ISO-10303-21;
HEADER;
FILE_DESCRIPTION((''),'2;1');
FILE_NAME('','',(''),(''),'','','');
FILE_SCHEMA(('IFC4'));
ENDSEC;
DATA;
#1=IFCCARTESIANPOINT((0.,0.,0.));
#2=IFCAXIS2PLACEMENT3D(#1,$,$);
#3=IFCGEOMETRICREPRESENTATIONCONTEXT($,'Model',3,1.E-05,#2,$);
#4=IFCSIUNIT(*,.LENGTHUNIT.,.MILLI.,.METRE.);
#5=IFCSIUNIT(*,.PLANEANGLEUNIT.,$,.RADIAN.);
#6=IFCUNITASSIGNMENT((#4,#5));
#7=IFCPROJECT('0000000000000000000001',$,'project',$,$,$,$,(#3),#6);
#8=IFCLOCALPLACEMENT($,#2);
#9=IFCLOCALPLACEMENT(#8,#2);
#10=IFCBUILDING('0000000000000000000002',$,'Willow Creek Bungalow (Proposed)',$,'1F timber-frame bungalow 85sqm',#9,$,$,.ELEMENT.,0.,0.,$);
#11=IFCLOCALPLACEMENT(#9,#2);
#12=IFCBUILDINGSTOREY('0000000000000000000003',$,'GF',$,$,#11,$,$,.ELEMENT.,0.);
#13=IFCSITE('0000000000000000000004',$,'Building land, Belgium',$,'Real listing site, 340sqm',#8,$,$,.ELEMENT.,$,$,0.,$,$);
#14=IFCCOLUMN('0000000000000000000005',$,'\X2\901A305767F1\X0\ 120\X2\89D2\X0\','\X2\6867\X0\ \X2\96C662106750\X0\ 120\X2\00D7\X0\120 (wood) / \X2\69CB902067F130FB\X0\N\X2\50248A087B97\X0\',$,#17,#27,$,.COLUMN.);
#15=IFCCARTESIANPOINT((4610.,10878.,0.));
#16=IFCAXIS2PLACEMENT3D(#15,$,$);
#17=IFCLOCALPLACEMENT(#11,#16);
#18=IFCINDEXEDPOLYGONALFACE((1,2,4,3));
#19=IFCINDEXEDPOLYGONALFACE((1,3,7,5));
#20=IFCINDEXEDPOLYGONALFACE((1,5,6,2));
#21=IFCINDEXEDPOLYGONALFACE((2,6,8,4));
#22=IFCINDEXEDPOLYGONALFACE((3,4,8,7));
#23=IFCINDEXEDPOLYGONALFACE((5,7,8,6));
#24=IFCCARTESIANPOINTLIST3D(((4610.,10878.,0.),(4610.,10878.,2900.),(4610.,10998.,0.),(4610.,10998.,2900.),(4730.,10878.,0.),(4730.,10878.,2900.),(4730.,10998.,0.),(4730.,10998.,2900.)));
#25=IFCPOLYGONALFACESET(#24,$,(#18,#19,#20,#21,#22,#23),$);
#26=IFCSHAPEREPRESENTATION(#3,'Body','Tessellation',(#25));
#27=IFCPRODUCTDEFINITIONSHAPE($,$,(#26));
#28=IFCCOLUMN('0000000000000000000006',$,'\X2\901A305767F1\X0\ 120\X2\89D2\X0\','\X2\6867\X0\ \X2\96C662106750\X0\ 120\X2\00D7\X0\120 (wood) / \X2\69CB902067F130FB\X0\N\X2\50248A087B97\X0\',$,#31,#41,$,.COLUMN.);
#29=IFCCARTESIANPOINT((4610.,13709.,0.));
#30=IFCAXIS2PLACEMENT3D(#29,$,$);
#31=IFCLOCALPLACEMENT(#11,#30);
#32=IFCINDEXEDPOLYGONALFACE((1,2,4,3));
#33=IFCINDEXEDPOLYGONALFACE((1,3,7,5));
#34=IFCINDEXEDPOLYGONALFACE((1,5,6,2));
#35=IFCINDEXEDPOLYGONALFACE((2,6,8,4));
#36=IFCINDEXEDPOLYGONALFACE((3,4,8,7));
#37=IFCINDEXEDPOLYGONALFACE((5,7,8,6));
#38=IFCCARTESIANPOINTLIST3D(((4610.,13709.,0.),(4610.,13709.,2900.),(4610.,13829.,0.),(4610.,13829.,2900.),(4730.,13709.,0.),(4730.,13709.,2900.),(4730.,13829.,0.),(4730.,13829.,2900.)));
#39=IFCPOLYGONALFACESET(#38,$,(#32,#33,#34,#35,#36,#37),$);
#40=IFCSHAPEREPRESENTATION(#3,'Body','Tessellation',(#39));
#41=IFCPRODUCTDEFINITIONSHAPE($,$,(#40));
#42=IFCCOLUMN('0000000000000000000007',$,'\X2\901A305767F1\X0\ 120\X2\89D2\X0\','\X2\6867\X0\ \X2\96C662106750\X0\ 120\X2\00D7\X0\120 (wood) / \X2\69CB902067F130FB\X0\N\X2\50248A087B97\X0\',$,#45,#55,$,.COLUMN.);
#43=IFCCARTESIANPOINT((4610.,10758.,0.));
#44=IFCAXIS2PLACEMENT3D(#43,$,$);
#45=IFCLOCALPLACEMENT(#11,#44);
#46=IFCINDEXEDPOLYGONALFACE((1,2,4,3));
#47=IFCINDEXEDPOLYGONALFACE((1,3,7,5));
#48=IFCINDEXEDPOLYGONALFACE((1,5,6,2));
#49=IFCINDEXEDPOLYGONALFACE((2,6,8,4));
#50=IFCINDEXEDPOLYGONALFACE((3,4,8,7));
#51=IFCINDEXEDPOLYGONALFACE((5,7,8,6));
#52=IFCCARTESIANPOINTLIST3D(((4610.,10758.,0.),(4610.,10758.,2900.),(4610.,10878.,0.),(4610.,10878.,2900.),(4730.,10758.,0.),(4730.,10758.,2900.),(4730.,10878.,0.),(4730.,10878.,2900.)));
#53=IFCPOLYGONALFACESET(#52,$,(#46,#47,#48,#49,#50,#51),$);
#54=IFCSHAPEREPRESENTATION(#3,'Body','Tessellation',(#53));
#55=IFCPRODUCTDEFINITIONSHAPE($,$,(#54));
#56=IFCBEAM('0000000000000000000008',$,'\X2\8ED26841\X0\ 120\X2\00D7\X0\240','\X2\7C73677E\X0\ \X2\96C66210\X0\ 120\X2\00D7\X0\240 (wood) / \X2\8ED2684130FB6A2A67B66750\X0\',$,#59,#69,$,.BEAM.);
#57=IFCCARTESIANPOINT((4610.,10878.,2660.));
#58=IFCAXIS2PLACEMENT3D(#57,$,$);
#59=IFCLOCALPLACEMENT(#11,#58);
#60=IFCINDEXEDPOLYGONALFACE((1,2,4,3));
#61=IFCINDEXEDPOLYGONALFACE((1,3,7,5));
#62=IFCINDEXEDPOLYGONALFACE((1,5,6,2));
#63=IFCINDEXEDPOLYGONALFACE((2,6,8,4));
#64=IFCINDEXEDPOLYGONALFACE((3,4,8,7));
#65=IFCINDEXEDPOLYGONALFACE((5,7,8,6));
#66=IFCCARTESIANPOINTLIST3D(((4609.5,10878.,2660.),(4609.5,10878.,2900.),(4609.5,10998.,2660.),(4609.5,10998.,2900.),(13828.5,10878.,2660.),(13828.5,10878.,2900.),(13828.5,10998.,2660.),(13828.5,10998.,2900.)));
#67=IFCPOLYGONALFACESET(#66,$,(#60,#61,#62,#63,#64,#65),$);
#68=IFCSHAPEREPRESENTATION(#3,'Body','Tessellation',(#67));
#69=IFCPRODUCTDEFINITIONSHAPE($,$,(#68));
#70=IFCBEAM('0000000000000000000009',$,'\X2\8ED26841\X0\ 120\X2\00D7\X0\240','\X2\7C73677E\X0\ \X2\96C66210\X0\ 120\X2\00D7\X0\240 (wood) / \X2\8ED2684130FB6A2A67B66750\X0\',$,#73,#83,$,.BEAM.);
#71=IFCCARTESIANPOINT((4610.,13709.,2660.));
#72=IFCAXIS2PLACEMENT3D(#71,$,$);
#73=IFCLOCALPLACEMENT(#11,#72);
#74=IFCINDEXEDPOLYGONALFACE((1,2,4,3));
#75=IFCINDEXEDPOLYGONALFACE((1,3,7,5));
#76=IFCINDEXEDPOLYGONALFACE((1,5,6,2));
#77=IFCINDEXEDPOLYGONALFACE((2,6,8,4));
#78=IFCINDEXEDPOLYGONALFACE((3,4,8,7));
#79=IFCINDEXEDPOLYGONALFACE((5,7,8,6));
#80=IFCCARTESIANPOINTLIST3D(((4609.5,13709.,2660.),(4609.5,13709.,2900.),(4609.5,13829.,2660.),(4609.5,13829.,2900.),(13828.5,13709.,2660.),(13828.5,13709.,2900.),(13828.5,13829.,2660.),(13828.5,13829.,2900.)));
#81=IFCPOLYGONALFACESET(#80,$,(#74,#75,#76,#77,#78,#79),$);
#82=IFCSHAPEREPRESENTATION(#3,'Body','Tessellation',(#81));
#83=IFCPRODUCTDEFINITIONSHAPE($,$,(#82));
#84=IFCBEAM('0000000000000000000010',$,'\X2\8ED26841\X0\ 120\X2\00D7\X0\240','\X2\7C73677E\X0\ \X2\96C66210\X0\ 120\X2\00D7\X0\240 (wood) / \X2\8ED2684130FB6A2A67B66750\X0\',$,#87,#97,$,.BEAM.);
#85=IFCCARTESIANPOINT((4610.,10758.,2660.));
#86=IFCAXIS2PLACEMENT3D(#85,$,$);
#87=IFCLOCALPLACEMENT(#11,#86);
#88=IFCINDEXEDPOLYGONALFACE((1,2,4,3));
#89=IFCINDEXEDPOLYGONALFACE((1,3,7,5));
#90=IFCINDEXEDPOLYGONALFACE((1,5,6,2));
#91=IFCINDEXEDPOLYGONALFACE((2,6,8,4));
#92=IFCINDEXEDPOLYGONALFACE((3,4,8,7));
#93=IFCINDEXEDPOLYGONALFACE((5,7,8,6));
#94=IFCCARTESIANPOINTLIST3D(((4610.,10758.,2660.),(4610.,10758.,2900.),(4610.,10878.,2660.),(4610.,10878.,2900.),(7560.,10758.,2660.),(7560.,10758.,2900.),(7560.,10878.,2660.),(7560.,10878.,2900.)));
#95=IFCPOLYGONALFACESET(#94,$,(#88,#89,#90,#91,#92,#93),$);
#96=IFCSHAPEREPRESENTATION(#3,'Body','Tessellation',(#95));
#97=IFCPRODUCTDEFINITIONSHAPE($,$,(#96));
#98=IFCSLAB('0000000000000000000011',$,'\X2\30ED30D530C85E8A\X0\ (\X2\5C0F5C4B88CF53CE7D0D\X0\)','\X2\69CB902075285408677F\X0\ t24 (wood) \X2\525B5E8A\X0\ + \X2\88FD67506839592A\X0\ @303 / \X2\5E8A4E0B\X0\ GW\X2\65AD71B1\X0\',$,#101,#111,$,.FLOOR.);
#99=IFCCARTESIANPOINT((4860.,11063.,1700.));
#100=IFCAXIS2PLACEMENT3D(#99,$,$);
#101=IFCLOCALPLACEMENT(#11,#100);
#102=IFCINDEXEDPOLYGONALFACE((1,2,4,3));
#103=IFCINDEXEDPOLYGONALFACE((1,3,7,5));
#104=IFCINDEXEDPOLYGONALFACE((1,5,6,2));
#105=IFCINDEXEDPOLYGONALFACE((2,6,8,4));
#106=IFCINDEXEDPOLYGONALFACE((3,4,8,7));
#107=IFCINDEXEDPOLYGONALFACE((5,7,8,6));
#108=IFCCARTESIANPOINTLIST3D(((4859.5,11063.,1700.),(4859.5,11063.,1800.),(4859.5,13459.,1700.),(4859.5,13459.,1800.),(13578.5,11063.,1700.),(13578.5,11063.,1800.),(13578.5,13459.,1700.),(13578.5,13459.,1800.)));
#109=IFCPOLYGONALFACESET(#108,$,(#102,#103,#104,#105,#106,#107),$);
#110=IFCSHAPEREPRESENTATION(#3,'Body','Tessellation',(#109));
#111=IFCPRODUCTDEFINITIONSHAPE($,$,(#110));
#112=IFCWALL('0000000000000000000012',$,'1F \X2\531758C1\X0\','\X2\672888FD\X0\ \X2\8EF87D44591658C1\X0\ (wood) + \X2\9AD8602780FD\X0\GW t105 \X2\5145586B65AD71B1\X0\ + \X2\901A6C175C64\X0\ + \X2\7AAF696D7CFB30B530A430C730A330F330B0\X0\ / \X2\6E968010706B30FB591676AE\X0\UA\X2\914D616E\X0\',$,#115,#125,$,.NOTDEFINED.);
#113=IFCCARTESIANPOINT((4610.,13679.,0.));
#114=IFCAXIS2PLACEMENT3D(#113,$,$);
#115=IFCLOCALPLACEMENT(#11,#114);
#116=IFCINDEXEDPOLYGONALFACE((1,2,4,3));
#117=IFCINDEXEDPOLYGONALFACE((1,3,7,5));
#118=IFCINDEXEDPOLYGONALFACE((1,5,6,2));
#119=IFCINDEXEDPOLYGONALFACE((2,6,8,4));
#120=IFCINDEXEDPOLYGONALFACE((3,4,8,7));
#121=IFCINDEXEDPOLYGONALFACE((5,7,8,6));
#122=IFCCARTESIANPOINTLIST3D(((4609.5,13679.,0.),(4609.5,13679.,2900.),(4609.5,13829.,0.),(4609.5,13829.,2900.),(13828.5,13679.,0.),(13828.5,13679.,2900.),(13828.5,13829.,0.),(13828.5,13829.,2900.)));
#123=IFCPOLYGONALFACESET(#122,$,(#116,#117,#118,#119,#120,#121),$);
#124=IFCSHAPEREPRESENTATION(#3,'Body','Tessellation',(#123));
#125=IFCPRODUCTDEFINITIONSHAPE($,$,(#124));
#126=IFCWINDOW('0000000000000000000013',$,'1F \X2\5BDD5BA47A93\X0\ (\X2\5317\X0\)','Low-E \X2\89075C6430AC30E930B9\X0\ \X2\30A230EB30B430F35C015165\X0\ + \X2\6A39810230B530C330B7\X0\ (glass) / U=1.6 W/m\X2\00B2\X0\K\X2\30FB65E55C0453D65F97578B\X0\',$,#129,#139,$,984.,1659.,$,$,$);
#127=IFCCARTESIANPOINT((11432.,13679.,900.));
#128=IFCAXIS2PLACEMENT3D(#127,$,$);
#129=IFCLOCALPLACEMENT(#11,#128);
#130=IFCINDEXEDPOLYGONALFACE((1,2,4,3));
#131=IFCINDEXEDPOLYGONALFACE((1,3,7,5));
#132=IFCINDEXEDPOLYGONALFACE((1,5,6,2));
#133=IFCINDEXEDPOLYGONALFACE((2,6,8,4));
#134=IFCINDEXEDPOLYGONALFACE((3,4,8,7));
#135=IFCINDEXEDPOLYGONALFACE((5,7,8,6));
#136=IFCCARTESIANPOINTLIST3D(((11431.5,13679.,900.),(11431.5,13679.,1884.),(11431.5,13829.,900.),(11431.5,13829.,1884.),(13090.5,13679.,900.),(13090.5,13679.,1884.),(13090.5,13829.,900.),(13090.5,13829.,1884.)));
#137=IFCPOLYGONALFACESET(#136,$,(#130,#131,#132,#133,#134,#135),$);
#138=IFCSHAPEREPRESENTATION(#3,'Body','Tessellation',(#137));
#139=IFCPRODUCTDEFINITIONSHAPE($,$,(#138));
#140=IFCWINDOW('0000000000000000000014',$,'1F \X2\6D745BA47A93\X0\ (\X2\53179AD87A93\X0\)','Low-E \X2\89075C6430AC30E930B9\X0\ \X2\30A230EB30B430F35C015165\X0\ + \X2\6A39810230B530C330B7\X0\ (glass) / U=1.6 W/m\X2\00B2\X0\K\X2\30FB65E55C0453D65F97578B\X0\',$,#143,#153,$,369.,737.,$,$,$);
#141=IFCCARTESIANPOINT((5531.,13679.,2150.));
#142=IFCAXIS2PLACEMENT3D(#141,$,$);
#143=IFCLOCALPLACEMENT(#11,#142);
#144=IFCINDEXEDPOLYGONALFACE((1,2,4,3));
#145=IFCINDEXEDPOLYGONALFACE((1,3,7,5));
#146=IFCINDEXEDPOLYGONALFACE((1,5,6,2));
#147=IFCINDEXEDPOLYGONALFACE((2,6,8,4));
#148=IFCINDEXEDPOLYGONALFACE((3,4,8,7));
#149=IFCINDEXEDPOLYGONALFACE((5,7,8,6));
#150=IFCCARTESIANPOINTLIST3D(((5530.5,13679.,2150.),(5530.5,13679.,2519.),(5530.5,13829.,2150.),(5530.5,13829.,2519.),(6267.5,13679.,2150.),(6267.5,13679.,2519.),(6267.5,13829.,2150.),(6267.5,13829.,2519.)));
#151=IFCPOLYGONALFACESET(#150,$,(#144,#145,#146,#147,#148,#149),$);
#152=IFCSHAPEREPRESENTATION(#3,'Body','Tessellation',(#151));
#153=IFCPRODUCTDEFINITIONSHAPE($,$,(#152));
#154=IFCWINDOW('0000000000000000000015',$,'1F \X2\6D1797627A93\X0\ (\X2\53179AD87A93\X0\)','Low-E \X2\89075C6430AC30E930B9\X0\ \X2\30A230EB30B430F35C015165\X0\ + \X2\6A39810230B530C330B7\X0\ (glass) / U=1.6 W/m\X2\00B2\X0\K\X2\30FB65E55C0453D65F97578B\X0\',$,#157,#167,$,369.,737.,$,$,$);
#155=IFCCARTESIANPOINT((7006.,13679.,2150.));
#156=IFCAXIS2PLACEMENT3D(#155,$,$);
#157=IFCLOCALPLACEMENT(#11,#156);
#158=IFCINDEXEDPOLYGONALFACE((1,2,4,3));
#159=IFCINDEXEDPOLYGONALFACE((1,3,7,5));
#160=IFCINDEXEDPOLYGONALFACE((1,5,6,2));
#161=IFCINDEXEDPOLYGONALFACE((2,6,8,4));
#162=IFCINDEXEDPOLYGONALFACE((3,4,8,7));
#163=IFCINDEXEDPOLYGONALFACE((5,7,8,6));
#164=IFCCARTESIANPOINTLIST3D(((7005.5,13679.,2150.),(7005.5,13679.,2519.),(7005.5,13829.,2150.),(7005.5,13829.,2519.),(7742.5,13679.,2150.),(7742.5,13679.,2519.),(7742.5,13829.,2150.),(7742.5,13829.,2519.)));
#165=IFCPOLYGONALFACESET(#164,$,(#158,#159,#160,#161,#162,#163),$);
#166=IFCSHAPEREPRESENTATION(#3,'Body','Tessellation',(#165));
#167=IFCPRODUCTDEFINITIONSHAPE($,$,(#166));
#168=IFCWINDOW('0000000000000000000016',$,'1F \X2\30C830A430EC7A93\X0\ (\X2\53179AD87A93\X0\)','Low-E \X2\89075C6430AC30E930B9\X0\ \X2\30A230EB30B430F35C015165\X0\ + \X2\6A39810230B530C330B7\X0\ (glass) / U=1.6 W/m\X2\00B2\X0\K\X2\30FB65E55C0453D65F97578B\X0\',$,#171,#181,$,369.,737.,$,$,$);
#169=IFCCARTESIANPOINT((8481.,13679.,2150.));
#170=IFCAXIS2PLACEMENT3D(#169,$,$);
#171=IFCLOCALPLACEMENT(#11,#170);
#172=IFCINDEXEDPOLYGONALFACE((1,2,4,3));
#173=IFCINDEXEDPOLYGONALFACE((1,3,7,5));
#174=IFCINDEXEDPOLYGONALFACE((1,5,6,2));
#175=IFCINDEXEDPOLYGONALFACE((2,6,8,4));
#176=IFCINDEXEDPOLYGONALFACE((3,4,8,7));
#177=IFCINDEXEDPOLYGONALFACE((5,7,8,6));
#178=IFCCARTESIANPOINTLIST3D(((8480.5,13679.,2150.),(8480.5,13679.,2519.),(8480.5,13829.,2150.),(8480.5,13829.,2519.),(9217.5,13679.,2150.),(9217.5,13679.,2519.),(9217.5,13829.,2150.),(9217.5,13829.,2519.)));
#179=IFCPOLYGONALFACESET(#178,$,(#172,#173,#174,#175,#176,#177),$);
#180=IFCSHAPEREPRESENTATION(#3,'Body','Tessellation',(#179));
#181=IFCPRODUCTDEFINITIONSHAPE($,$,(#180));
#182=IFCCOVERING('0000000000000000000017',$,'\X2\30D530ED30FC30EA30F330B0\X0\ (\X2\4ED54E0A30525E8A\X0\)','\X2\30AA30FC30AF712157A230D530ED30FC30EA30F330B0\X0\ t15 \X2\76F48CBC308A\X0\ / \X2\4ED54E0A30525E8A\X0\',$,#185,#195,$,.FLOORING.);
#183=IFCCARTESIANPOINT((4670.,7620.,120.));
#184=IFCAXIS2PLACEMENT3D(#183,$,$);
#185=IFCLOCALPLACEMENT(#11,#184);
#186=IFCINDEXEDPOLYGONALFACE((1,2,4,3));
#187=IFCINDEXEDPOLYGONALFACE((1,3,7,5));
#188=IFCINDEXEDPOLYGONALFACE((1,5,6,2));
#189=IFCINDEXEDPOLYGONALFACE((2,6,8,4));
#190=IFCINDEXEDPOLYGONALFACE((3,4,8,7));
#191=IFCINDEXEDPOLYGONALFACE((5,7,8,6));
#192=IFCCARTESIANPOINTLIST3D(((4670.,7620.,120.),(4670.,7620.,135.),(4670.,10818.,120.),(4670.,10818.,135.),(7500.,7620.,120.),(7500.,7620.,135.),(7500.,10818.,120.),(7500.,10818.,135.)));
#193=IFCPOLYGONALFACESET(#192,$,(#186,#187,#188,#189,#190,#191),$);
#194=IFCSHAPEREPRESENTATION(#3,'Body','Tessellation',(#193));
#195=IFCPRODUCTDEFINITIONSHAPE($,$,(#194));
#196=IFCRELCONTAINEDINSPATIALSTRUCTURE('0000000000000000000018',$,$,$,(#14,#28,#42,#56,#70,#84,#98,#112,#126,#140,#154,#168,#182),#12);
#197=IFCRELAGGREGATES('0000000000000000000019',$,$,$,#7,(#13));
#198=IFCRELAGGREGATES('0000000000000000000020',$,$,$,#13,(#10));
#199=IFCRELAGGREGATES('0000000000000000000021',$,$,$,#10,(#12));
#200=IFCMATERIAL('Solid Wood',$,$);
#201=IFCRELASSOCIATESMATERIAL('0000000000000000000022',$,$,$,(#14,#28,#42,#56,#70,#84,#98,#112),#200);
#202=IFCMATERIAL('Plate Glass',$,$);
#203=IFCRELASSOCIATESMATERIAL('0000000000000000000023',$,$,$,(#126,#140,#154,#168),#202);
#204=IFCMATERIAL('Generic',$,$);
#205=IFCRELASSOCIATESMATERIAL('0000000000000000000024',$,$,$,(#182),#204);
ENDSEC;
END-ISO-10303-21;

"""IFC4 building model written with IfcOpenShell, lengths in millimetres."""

from ifc_helpers import new_model, si_unit, frame, frame_2d, origin, place, context, project, spatial, rectangle, extrude, material, element, fill, save


model = new_model("IFC4")

# Units and contexts
model_context = context("Model", 3, precision=1e-05, world=origin())
ifc_project = project(units=[si_unit("LENGTHUNIT", "METRE", prefix="MILLI"), si_unit("PLANEANGLEUNIT", "RADIAN")], contexts=[model_context])

# Site, building, storey
site_placement = place(None, origin())
site = spatial("IfcSite", under=ifc_project, at=site_placement, Name="Building land, Belgium", ObjectType="Real listing site, 340sqm", CompositionType="ELEMENT", RefElevation=0.0)
building_placement = place(site_placement, origin())
building = spatial("IfcBuilding", under=site, at=building_placement, Name="Willow Creek Bungalow (Proposed)", ObjectType="1F timber-frame bungalow 85sqm", CompositionType="ELEMENT", ElevationOfRefHeight=0.0, ElevationOfTerrain=0.0)
storey_placement = place(building_placement, origin())
storey = spatial("IfcBuildingStorey", under=building, at=storey_placement, Name="GF", CompositionType="ELEMENT", Elevation=0.0)

# Columns
ifc_material_1 = material(Name="Solid Wood")
column_1_placement = place(storey_placement, frame((4610.0, 10878.0, 0.0)))
element("IfcColumn", 1, at=column_1_placement, inside=storey, material=ifc_material_1, Name="通し柱 120角", Description="桧 集成材 120×120 (wood) / 構造柱・N値計算", PredefinedType="COLUMN", context=model_context, shape_type="SweptSolid", body=[
    extrude(rectangle(XDim=120.0, YDim=120.0, at=frame_2d((60.0, 60.0))), frame((4610.0, 10878.0, 0.0)), (0.0, 0.0, 1.0), 2900.0),
])
column_2_placement = place(storey_placement, frame((4610.0, 13709.0, 0.0)))
element("IfcColumn", 2, at=column_2_placement, inside=storey, material=ifc_material_1, Name="通し柱 120角", Description="桧 集成材 120×120 (wood) / 構造柱・N値計算", PredefinedType="COLUMN", context=model_context, shape_type="SweptSolid", body=[
    extrude(rectangle(XDim=120.0, YDim=120.0, at=frame_2d((60.0, 60.0))), frame((4610.0, 13709.0, 0.0)), (0.0, 0.0, 1.0), 2900.0),
])
column_3_placement = place(storey_placement, frame((4610.0, 10758.0, 0.0)))
element("IfcColumn", 3, at=column_3_placement, inside=storey, material=ifc_material_1, Name="通し柱 120角", Description="桧 集成材 120×120 (wood) / 構造柱・N値計算", PredefinedType="COLUMN", context=model_context, shape_type="SweptSolid", body=[
    extrude(rectangle(XDim=120.0, YDim=120.0, at=frame_2d((60.0, 60.0))), frame((4610.0, 10758.0, 0.0)), (0.0, 0.0, 1.0), 2900.0),
])

# Beams
beam_1_placement = place(storey_placement, frame((4610.0, 10878.0, 2660.0)))
element("IfcBeam", 4, at=beam_1_placement, inside=storey, material=ifc_material_1, Name="軒桁 120×240", Description="米松 集成 120×240 (wood) / 軒桁・横架材", PredefinedType="BEAM", context=model_context, shape_type="SweptSolid", body=[
    extrude(rectangle(XDim=9219.0, YDim=120.0, at=frame_2d((4609.0, 60.0))), frame((4610.0, 10878.0, 2660.0)), (0.0, 0.0, 1.0), 240.0),
])
beam_2_placement = place(storey_placement, frame((4610.0, 13709.0, 2660.0)))
element("IfcBeam", 5, at=beam_2_placement, inside=storey, material=ifc_material_1, Name="軒桁 120×240", Description="米松 集成 120×240 (wood) / 軒桁・横架材", PredefinedType="BEAM", context=model_context, shape_type="SweptSolid", body=[
    extrude(rectangle(XDim=9219.0, YDim=120.0, at=frame_2d((4609.0, 60.0))), frame((4610.0, 13709.0, 2660.0)), (0.0, 0.0, 1.0), 240.0),
])
beam_3_placement = place(storey_placement, frame((4610.0, 10758.0, 2660.0)))
element("IfcBeam", 6, at=beam_3_placement, inside=storey, material=ifc_material_1, Name="軒桁 120×240", Description="米松 集成 120×240 (wood) / 軒桁・横架材", PredefinedType="BEAM", context=model_context, shape_type="SweptSolid", body=[
    extrude(rectangle(XDim=2950.0, YDim=120.0, at=frame_2d((1475.0, 60.0))), frame((4610.0, 10758.0, 2660.0)), (0.0, 0.0, 1.0), 240.0),
])

# Slab
slab_1_placement = place(storey_placement, frame((4860.0, 11063.0, 1700.0)))
element("IfcSlab", 7, at=slab_1_placement, inside=storey, material=ifc_material_1, Name="ロフト床 (小屋裏収納)", Description="構造用合板 t24 (wood) 剛床 + 製材根太 @303 / 床下 GW断熱", PredefinedType="FLOOR", context=model_context, shape_type="SweptSolid", body=[
    extrude(rectangle(XDim=8719.0, YDim=2396.0, at=frame_2d((4359.0, 1198.0))), frame((4860.0, 11063.0, 1700.0)), (0.0, 0.0, 1.0), 100.0),
])

# Wall, openings, windows
wall_1_placement = place(storey_placement, frame((4610.0, 13679.0, 0.0)))
wall_1 = element("IfcWall", 8, at=wall_1_placement, inside=storey, material=ifc_material_1, Name="1F 北壁", Description="木製 軸組外壁 (wood) + 高性能GW t105 充填断熱 + 通気層 + 窯業系サイディング / 準耐火・外皮UA配慮", PredefinedType="NOTDEFINED", context=model_context, shape_type="SweptSolid", body=[
    extrude(rectangle(XDim=9219.0, YDim=150.0, at=frame_2d((4609.0, 75.0))), frame((4610.0, 13679.0, 0.0)), (0.0, 0.0, 1.0), 2900.0),
])
opening_1_placement = place(storey_placement, frame((11432.0, 13679.0, 900.0)))
opening_1 = element("IfcOpeningElement", 9, at=opening_1_placement, cuts=wall_1, PredefinedType="NOTDEFINED", context=model_context, shape_type="SweptSolid", body=[
    extrude(rectangle(XDim=1659.0, YDim=150.0, at=frame_2d((829.0, 75.0))), frame((11432.0, 13679.0, 900.0)), (0.0, 0.0, 1.0), 984.0),
])
opening_2_placement = place(storey_placement, frame((5531.0, 13679.0, 2150.0)))
opening_2 = element("IfcOpeningElement", 10, at=opening_2_placement, cuts=wall_1, PredefinedType="NOTDEFINED", context=model_context, shape_type="SweptSolid", body=[
    extrude(rectangle(XDim=737.0, YDim=150.0, at=frame_2d((368.0, 75.0))), frame((5531.0, 13679.0, 2150.0)), (0.0, 0.0, 1.0), 369.0),
])
opening_3_placement = place(storey_placement, frame((7006.0, 13679.0, 2150.0)))
opening_3 = element("IfcOpeningElement", 11, at=opening_3_placement, cuts=wall_1, PredefinedType="NOTDEFINED", context=model_context, shape_type="SweptSolid", body=[
    extrude(rectangle(XDim=737.0, YDim=150.0, at=frame_2d((368.0, 75.0))), frame((7006.0, 13679.0, 2150.0)), (0.0, 0.0, 1.0), 369.0),
])
opening_4_placement = place(storey_placement, frame((8481.0, 13679.0, 2150.0)))
opening_4 = element("IfcOpeningElement", 12, at=opening_4_placement, cuts=wall_1, PredefinedType="NOTDEFINED", context=model_context, shape_type="SweptSolid", body=[
    extrude(rectangle(XDim=737.0, YDim=150.0, at=frame_2d((368.0, 75.0))), frame((8481.0, 13679.0, 2150.0)), (0.0, 0.0, 1.0), 369.0),
])
ifc_material_2 = material(Name="Plate Glass")
window_1_placement = place(storey_placement, frame((11432.0, 13679.0, 900.0)))
window_1 = element("IfcWindow", 13, at=window_1_placement, inside=storey, material=ifc_material_2, Name="1F 寝室窓 (北)", Description="Low-E 複層ガラス アルゴン封入 + 樹脂サッシ (glass) / U=1.6 W/m²K・日射取得型", OverallHeight=984.0, OverallWidth=1659.0, context=model_context, shape_type="SweptSolid", body=[
    extrude(rectangle(XDim=1659.0, YDim=150.0, at=frame_2d((829.0, 75.0))), frame((11432.0, 13679.0, 900.0)), (0.0, 0.0, 1.0), 984.0),
])
fill(opening_1, window_1)
window_2_placement = place(storey_placement, frame((5531.0, 13679.0, 2150.0)))
window_2 = element("IfcWindow", 14, at=window_2_placement, inside=storey, material=ifc_material_2, Name="1F 浴室窓 (北高窓)", Description="Low-E 複層ガラス アルゴン封入 + 樹脂サッシ (glass) / U=1.6 W/m²K・日射取得型", OverallHeight=369.0, OverallWidth=737.0, context=model_context, shape_type="SweptSolid", body=[
    extrude(rectangle(XDim=737.0, YDim=150.0, at=frame_2d((368.0, 75.0))), frame((5531.0, 13679.0, 2150.0)), (0.0, 0.0, 1.0), 369.0),
])
fill(opening_2, window_2)
window_3_placement = place(storey_placement, frame((7006.0, 13679.0, 2150.0)))
window_3 = element("IfcWindow", 15, at=window_3_placement, inside=storey, material=ifc_material_2, Name="1F 洗面窓 (北高窓)", Description="Low-E 複層ガラス アルゴン封入 + 樹脂サッシ (glass) / U=1.6 W/m²K・日射取得型", OverallHeight=369.0, OverallWidth=737.0, context=model_context, shape_type="SweptSolid", body=[
    extrude(rectangle(XDim=737.0, YDim=150.0, at=frame_2d((368.0, 75.0))), frame((7006.0, 13679.0, 2150.0)), (0.0, 0.0, 1.0), 369.0),
])
fill(opening_3, window_3)
window_4_placement = place(storey_placement, frame((8481.0, 13679.0, 2150.0)))
window_4 = element("IfcWindow", 16, at=window_4_placement, inside=storey, material=ifc_material_2, Name="1F トイレ窓 (北高窓)", Description="Low-E 複層ガラス アルゴン封入 + 樹脂サッシ (glass) / U=1.6 W/m²K・日射取得型", OverallHeight=369.0, OverallWidth=737.0, context=model_context, shape_type="SweptSolid", body=[
    extrude(rectangle(XDim=737.0, YDim=150.0, at=frame_2d((368.0, 75.0))), frame((8481.0, 13679.0, 2150.0)), (0.0, 0.0, 1.0), 369.0),
])
fill(opening_4, window_4)

# Covering
ifc_material_3 = material(Name="Generic")
covering_1_placement = place(storey_placement, frame((4670.0, 7620.0, 120.0)))
element("IfcCovering", 17, at=covering_1_placement, inside=storey, material=ifc_material_3, Name="フローリング (仕上げ床)", Description="オーク無垢フローリング t15 直貼り / 仕上げ床", PredefinedType="FLOORING", context=model_context, shape_type="SweptSolid", body=[
    extrude(rectangle(XDim=2830.0, YDim=3198.0, at=frame_2d((1415.0, 1599.0))), frame((4670.0, 7620.0, 120.0)), (0.0, 0.0, 1.0), 15.0),
])

save(model, "model.ifc")
